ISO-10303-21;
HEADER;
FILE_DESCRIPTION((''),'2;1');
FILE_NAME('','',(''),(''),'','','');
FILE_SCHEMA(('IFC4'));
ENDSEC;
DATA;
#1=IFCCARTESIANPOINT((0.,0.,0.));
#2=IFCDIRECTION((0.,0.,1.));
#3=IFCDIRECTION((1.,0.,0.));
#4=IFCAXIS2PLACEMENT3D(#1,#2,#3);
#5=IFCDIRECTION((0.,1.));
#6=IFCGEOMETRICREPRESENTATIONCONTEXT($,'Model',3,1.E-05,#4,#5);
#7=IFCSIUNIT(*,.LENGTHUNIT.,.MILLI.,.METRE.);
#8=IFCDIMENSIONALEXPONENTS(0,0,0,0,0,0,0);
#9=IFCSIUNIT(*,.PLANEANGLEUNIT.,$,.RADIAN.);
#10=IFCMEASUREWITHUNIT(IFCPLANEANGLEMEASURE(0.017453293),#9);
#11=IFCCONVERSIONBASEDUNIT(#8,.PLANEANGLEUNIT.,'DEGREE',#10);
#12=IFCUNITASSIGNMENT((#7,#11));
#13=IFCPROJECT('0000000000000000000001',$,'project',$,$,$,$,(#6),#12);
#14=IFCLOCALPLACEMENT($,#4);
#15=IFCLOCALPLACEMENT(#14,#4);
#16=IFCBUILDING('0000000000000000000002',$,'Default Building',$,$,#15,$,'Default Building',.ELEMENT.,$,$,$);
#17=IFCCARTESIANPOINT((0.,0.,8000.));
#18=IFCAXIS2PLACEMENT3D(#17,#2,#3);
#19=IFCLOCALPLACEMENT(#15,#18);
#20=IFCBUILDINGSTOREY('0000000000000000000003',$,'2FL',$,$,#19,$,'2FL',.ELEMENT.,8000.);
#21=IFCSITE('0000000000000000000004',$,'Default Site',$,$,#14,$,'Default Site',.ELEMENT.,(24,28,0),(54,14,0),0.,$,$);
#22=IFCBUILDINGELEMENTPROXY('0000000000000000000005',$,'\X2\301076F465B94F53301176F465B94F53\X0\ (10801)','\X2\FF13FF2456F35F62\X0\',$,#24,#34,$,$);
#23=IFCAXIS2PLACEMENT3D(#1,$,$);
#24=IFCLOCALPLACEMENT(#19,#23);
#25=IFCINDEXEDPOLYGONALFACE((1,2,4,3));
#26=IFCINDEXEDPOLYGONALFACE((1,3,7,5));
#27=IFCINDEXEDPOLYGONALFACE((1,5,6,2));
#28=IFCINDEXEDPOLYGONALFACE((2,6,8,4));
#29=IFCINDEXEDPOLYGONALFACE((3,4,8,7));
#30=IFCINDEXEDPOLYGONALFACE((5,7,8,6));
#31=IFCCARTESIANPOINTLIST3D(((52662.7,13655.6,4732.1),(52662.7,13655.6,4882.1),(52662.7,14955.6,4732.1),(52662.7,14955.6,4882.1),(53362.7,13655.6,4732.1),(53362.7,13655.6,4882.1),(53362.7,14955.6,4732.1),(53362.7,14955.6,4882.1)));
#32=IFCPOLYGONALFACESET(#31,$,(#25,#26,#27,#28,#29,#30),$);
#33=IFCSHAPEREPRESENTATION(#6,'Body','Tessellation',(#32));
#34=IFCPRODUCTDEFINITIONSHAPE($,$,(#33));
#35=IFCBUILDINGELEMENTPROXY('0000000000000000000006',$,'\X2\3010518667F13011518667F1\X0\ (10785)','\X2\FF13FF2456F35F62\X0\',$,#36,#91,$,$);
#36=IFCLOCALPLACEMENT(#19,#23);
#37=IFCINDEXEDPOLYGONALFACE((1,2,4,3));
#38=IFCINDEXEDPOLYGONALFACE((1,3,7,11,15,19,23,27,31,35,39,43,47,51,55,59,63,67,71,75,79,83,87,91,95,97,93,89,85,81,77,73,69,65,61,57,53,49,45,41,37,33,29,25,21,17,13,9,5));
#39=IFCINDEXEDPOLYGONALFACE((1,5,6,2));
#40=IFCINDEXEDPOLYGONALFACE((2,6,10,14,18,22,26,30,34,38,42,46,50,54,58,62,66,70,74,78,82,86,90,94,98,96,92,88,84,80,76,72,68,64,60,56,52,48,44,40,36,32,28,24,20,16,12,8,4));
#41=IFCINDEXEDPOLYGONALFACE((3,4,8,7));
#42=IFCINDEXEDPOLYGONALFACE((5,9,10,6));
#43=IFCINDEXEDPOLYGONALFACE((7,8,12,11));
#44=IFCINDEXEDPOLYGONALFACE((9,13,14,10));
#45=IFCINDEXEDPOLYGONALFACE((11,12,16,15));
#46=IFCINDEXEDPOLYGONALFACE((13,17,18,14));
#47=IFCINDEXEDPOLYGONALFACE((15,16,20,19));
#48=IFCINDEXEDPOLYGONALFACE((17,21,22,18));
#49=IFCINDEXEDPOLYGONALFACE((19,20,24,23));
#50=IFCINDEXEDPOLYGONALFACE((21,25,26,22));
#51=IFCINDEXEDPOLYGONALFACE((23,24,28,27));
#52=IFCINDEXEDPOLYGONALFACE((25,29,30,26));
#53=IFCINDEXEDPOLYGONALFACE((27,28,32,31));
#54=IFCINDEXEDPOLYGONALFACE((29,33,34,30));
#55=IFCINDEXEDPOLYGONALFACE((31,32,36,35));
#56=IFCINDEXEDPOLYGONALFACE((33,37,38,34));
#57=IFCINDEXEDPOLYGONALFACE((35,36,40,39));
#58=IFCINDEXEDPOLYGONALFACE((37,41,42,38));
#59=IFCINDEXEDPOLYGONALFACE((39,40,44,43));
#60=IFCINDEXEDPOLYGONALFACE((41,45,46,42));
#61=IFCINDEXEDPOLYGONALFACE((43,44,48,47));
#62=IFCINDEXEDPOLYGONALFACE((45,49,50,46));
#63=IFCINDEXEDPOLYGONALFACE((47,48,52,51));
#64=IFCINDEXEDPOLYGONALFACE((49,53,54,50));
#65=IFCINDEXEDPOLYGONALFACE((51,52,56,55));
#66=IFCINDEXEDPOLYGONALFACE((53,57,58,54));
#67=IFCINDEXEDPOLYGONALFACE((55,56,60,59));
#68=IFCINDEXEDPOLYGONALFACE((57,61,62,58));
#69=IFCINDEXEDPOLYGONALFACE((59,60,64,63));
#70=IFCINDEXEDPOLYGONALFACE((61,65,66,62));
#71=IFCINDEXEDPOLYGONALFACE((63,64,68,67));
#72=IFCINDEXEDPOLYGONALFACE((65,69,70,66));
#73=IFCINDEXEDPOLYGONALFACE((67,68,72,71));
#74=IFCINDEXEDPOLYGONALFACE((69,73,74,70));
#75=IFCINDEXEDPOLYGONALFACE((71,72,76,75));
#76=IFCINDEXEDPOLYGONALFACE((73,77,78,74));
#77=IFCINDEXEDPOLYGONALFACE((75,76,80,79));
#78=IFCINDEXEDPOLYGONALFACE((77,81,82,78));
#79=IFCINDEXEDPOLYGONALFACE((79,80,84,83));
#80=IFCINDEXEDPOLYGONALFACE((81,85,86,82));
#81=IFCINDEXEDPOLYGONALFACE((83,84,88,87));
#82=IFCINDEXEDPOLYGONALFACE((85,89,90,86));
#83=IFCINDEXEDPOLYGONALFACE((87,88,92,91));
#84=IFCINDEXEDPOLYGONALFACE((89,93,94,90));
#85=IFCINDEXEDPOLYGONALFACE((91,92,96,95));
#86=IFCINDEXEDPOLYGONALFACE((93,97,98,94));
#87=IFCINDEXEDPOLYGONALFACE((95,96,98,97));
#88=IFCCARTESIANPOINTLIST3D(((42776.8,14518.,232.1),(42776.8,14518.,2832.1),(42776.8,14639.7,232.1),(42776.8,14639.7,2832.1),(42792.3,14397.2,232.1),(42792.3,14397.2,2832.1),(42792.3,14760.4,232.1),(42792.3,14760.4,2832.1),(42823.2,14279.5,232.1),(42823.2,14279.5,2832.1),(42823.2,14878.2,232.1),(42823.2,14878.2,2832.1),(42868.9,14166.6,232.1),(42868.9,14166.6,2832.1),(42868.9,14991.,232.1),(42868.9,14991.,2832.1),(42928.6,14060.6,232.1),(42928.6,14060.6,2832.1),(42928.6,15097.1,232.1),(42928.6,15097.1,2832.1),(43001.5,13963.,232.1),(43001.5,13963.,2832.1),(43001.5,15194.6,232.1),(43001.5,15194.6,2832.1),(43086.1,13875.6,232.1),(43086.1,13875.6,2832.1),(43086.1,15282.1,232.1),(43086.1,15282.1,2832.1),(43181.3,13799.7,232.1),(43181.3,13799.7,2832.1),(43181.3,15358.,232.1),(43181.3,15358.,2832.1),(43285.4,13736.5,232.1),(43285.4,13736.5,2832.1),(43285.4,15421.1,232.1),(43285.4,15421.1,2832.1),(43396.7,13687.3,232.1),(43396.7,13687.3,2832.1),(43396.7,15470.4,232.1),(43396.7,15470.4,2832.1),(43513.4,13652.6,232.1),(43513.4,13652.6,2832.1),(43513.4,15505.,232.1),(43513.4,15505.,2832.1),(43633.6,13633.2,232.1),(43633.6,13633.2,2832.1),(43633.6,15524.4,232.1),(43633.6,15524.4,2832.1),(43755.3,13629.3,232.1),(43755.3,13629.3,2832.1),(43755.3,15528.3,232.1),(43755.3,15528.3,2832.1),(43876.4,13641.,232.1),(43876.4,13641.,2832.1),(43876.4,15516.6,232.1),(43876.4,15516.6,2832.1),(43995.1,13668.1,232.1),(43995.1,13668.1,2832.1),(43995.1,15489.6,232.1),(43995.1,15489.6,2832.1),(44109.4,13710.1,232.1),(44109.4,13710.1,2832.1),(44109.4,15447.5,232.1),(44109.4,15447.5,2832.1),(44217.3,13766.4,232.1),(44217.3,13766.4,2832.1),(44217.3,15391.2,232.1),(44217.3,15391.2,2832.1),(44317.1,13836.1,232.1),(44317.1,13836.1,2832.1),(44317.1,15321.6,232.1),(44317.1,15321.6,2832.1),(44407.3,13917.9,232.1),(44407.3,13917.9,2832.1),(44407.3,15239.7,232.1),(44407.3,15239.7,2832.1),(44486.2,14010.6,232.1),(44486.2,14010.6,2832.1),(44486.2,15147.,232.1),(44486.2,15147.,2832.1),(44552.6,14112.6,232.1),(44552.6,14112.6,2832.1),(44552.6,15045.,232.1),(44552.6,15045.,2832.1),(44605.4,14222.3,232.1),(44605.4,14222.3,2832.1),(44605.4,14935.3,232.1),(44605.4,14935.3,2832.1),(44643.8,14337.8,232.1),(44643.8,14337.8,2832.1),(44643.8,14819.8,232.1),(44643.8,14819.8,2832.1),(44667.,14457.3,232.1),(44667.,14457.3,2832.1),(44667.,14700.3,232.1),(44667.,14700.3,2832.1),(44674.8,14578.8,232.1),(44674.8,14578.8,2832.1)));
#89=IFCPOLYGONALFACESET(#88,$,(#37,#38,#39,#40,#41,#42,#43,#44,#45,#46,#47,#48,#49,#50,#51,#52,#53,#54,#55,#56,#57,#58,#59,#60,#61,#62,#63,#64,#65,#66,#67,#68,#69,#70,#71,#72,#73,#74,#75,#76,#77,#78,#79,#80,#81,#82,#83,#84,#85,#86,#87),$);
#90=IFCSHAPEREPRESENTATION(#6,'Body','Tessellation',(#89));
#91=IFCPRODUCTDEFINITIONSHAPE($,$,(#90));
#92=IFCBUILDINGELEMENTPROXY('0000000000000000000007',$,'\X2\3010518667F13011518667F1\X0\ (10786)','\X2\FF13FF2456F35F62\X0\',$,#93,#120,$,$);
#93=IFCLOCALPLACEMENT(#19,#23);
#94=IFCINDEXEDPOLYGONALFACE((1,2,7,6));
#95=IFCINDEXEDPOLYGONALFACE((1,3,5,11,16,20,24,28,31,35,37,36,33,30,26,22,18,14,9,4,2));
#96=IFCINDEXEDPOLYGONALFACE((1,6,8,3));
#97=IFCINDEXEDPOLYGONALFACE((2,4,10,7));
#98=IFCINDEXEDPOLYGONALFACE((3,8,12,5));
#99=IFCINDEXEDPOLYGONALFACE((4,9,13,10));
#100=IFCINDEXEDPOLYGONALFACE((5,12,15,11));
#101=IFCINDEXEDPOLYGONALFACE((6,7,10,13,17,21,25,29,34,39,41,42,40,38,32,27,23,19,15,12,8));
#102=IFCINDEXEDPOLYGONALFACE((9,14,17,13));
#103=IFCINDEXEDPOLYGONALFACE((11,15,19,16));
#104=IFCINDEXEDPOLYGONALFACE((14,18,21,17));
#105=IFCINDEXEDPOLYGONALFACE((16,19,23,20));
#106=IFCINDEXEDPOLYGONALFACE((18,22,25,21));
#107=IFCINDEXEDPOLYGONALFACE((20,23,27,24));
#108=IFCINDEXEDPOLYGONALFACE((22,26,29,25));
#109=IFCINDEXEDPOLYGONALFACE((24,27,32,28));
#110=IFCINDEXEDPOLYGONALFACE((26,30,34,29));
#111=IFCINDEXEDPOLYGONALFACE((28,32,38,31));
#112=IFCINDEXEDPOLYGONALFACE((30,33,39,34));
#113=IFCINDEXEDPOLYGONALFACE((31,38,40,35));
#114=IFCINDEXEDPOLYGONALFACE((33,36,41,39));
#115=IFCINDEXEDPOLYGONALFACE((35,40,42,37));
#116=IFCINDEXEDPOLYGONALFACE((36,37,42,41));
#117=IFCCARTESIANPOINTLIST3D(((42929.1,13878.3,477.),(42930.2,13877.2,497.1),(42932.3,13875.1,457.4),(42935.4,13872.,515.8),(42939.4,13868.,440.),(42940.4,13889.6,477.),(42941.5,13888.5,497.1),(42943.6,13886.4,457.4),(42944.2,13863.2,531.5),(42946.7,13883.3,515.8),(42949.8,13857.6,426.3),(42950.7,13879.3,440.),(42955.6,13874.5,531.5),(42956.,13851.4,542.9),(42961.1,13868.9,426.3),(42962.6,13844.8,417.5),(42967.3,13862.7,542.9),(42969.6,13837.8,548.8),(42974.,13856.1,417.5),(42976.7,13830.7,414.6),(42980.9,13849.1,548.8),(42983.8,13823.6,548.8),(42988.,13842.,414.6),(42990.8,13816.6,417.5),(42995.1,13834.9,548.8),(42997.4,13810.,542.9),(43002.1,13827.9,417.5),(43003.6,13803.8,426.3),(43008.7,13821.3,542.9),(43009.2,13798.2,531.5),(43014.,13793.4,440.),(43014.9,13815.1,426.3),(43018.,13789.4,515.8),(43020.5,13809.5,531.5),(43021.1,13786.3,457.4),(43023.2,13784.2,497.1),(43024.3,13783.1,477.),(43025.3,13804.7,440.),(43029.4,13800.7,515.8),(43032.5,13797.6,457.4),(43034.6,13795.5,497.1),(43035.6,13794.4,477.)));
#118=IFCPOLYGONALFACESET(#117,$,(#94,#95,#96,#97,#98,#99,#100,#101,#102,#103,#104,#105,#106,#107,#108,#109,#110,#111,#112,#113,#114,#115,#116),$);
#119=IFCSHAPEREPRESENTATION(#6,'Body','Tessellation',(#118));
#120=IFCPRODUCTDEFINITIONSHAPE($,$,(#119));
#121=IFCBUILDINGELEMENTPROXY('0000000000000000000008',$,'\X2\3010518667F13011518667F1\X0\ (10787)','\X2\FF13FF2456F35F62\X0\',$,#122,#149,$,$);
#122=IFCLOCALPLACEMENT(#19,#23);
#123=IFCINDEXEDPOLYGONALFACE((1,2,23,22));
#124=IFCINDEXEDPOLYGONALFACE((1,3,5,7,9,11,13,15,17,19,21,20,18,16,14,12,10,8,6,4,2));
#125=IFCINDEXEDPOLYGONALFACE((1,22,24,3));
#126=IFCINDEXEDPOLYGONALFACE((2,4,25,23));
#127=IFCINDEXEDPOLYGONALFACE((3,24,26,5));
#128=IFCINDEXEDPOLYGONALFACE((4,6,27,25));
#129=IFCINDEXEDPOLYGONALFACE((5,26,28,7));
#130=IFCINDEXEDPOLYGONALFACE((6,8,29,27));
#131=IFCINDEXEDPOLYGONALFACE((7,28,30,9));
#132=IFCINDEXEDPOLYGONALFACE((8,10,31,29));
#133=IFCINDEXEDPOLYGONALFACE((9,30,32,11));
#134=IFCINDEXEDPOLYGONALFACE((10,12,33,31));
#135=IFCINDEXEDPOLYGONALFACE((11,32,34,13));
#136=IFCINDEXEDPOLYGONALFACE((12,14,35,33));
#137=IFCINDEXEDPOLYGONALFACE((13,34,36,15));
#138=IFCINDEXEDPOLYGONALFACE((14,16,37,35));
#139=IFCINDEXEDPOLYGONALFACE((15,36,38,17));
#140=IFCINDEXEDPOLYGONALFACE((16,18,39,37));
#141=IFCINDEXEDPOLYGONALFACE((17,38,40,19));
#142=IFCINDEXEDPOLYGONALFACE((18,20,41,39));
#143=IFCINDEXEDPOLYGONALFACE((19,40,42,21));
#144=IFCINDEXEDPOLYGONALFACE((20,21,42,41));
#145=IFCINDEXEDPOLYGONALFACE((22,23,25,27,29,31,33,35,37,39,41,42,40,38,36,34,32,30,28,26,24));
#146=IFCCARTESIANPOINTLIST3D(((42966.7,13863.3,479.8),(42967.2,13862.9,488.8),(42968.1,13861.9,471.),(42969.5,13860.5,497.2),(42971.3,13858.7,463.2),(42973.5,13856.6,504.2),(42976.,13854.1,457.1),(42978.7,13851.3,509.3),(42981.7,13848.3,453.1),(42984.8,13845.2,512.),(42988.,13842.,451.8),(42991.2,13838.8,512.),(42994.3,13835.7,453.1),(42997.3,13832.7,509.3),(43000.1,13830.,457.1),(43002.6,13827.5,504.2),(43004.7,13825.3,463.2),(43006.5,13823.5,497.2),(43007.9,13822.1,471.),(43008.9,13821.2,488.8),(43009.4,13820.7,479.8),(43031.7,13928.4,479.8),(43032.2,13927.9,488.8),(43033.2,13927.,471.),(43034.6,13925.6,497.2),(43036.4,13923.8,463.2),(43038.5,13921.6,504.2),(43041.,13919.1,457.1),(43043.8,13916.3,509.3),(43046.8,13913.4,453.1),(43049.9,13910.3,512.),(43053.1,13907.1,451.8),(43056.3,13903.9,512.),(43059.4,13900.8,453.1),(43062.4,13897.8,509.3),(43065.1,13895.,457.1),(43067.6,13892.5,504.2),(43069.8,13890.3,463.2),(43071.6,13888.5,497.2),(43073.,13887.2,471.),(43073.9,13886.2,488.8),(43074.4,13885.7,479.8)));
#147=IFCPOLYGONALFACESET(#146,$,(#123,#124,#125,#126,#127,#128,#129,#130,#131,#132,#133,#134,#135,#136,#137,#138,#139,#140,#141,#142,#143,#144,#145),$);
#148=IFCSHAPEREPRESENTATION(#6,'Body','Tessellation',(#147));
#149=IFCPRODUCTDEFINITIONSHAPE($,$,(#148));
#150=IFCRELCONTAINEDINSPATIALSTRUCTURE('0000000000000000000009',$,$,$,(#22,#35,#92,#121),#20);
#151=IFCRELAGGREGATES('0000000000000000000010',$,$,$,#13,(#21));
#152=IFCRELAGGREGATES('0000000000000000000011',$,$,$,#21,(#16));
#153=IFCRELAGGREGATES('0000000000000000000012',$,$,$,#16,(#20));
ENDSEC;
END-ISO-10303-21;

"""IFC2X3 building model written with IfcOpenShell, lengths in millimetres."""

from ifc_helpers import new_model, entity, si_unit, converted_unit, direction, frame, origin_with_axes, origin_2d_with_axis, place, context, project, spatial, rectangle, circle, extrude, source, transform, mapped, element, save


model = new_model("IFC2X3")

# Units and contexts
model_context = context("Model", 3, precision=1e-05, world=origin_with_axes(), true_north=direction((0.0, 1.0)))
ifc_project = project(units=[si_unit("LENGTHUNIT", "METRE", prefix="MILLI"), converted_unit("PLANEANGLEUNIT", "DEGREE", entity("IfcPlaneAngleMeasure", 0.017453293), si_unit("PLANEANGLEUNIT", "RADIAN"), dimensions=[0, 0, 0, 0, 0, 0, 0])], contexts=[model_context])

# Site, building, storey
site_placement = place(None, origin_with_axes())
site = spatial("IfcSite", under=ifc_project, at=site_placement, Name="Default Site", LongName="Default Site", CompositionType="ELEMENT", RefLatitude=(24, 28, 0), RefLongitude=(54, 14, 0), RefElevation=0.0)
building_placement = place(site_placement, origin_with_axes())
building = spatial("IfcBuilding", under=site, at=building_placement, Name="Default Building", LongName="Default Building", CompositionType="ELEMENT")
storey_placement = place(building_placement, frame((0.0, 0.0, 8000.0), z_axis=(0.0, 0.0, 1.0), x_axis=(1.0, 0.0, 0.0)))
storey = spatial("IfcBuildingStorey", under=building, at=storey_placement, Name="2FL", LongName="2FL", CompositionType="ELEMENT", Elevation=8000.0)

# Building element proxies
shared_shape_1 = source(origin_with_axes(), model_context, "Body", "SweptSolid", [
    extrude(rectangle(XDim=700.0, YDim=1300.0, at=origin_2d_with_axis()), origin_with_axes(), (0.0, 0.0, 1.0), 150.0),
])
proxy_1_placement = place(storey_placement, frame((53012.7, 14305.6, 4732.1), z_axis=(0.0, 0.0, 1.0), x_axis=(1.0, 0.0, 0.0)))
element("IfcBuildingElementProxy", 1, at=proxy_1_placement, inside=storey, Name="【直方体】直方体 (10801)", Description="３Ｄ図形", context=model_context, shape_type="MappedRepresentation", body=[
    mapped(shared_shape_1, transform((0.0, 0.0, 0.0))),
])
shared_shape_2 = source(origin_with_axes(), model_context, "Body", "SweptSolid", [
    extrude(circle(Radius=950.0, at=origin_2d_with_axis()), origin_with_axes(), (0.0, 0.0, 1.0), 2600.0),
])
proxy_2_placement = place(storey_placement, frame((43724.8, 14578.8, 232.1), z_axis=(0.0, 0.0, 1.0), x_axis=(1.0, 0.0, 0.0)))
element("IfcBuildingElementProxy", 2, at=proxy_2_placement, inside=storey, Name="【円柱】円柱 (10785)", Description="３Ｄ図形", context=model_context, shape_type="MappedRepresentation", body=[
    mapped(shared_shape_2, transform((0.0, 0.0, 0.0))),
])
shared_shape_3 = source(origin_with_axes(), model_context, "Body", "SweptSolid", [
    extrude(circle(Radius=67.5, at=origin_2d_with_axis()), frame((0.0, 0.0, 0.0), z_axis=(0.0, 0.0, 1.0), x_axis=(1.0, 0.0, 0.0)), (0.0, 0.0, 1.0), 16.0),
])
proxy_3_placement = place(storey_placement, frame((42976.7, 13830.7, 482.1), z_axis=(0.707107, 0.707107, 0.0), x_axis=(0.0, 0.0, -1.0)))
element("IfcBuildingElementProxy", 3, at=proxy_3_placement, inside=storey, Name="【円柱】円柱 (10786)", Description="３Ｄ図形", context=model_context, shape_type="MappedRepresentation", body=[
    mapped(shared_shape_3, transform((0.0, 0.0, 0.0))),
])
shared_shape_4 = source(origin_with_axes(), model_context, "Body", "SweptSolid", [
    extrude(circle(Radius=30.2, at=origin_2d_with_axis()), frame((0.0, 0.0, 0.0), z_axis=(0.0, 0.0, 1.0), x_axis=(1.0, 0.0, 0.0)), (0.0, 0.0, 1.0), 92.0),
])
proxy_4_placement = place(storey_placement, frame((43053.1, 13907.1, 482.1), z_axis=(-0.707107, -0.707107, 0.0), x_axis=(0.0, 0.0, -1.0)))
element("IfcBuildingElementProxy", 4, at=proxy_4_placement, inside=storey, Name="【円柱】円柱 (10787)", Description="３Ｄ図形", context=model_context, shape_type="MappedRepresentation", body=[
    mapped(shared_shape_4, transform((0.0, 0.0, 0.0))),
])

save(model, "model.ifc")
